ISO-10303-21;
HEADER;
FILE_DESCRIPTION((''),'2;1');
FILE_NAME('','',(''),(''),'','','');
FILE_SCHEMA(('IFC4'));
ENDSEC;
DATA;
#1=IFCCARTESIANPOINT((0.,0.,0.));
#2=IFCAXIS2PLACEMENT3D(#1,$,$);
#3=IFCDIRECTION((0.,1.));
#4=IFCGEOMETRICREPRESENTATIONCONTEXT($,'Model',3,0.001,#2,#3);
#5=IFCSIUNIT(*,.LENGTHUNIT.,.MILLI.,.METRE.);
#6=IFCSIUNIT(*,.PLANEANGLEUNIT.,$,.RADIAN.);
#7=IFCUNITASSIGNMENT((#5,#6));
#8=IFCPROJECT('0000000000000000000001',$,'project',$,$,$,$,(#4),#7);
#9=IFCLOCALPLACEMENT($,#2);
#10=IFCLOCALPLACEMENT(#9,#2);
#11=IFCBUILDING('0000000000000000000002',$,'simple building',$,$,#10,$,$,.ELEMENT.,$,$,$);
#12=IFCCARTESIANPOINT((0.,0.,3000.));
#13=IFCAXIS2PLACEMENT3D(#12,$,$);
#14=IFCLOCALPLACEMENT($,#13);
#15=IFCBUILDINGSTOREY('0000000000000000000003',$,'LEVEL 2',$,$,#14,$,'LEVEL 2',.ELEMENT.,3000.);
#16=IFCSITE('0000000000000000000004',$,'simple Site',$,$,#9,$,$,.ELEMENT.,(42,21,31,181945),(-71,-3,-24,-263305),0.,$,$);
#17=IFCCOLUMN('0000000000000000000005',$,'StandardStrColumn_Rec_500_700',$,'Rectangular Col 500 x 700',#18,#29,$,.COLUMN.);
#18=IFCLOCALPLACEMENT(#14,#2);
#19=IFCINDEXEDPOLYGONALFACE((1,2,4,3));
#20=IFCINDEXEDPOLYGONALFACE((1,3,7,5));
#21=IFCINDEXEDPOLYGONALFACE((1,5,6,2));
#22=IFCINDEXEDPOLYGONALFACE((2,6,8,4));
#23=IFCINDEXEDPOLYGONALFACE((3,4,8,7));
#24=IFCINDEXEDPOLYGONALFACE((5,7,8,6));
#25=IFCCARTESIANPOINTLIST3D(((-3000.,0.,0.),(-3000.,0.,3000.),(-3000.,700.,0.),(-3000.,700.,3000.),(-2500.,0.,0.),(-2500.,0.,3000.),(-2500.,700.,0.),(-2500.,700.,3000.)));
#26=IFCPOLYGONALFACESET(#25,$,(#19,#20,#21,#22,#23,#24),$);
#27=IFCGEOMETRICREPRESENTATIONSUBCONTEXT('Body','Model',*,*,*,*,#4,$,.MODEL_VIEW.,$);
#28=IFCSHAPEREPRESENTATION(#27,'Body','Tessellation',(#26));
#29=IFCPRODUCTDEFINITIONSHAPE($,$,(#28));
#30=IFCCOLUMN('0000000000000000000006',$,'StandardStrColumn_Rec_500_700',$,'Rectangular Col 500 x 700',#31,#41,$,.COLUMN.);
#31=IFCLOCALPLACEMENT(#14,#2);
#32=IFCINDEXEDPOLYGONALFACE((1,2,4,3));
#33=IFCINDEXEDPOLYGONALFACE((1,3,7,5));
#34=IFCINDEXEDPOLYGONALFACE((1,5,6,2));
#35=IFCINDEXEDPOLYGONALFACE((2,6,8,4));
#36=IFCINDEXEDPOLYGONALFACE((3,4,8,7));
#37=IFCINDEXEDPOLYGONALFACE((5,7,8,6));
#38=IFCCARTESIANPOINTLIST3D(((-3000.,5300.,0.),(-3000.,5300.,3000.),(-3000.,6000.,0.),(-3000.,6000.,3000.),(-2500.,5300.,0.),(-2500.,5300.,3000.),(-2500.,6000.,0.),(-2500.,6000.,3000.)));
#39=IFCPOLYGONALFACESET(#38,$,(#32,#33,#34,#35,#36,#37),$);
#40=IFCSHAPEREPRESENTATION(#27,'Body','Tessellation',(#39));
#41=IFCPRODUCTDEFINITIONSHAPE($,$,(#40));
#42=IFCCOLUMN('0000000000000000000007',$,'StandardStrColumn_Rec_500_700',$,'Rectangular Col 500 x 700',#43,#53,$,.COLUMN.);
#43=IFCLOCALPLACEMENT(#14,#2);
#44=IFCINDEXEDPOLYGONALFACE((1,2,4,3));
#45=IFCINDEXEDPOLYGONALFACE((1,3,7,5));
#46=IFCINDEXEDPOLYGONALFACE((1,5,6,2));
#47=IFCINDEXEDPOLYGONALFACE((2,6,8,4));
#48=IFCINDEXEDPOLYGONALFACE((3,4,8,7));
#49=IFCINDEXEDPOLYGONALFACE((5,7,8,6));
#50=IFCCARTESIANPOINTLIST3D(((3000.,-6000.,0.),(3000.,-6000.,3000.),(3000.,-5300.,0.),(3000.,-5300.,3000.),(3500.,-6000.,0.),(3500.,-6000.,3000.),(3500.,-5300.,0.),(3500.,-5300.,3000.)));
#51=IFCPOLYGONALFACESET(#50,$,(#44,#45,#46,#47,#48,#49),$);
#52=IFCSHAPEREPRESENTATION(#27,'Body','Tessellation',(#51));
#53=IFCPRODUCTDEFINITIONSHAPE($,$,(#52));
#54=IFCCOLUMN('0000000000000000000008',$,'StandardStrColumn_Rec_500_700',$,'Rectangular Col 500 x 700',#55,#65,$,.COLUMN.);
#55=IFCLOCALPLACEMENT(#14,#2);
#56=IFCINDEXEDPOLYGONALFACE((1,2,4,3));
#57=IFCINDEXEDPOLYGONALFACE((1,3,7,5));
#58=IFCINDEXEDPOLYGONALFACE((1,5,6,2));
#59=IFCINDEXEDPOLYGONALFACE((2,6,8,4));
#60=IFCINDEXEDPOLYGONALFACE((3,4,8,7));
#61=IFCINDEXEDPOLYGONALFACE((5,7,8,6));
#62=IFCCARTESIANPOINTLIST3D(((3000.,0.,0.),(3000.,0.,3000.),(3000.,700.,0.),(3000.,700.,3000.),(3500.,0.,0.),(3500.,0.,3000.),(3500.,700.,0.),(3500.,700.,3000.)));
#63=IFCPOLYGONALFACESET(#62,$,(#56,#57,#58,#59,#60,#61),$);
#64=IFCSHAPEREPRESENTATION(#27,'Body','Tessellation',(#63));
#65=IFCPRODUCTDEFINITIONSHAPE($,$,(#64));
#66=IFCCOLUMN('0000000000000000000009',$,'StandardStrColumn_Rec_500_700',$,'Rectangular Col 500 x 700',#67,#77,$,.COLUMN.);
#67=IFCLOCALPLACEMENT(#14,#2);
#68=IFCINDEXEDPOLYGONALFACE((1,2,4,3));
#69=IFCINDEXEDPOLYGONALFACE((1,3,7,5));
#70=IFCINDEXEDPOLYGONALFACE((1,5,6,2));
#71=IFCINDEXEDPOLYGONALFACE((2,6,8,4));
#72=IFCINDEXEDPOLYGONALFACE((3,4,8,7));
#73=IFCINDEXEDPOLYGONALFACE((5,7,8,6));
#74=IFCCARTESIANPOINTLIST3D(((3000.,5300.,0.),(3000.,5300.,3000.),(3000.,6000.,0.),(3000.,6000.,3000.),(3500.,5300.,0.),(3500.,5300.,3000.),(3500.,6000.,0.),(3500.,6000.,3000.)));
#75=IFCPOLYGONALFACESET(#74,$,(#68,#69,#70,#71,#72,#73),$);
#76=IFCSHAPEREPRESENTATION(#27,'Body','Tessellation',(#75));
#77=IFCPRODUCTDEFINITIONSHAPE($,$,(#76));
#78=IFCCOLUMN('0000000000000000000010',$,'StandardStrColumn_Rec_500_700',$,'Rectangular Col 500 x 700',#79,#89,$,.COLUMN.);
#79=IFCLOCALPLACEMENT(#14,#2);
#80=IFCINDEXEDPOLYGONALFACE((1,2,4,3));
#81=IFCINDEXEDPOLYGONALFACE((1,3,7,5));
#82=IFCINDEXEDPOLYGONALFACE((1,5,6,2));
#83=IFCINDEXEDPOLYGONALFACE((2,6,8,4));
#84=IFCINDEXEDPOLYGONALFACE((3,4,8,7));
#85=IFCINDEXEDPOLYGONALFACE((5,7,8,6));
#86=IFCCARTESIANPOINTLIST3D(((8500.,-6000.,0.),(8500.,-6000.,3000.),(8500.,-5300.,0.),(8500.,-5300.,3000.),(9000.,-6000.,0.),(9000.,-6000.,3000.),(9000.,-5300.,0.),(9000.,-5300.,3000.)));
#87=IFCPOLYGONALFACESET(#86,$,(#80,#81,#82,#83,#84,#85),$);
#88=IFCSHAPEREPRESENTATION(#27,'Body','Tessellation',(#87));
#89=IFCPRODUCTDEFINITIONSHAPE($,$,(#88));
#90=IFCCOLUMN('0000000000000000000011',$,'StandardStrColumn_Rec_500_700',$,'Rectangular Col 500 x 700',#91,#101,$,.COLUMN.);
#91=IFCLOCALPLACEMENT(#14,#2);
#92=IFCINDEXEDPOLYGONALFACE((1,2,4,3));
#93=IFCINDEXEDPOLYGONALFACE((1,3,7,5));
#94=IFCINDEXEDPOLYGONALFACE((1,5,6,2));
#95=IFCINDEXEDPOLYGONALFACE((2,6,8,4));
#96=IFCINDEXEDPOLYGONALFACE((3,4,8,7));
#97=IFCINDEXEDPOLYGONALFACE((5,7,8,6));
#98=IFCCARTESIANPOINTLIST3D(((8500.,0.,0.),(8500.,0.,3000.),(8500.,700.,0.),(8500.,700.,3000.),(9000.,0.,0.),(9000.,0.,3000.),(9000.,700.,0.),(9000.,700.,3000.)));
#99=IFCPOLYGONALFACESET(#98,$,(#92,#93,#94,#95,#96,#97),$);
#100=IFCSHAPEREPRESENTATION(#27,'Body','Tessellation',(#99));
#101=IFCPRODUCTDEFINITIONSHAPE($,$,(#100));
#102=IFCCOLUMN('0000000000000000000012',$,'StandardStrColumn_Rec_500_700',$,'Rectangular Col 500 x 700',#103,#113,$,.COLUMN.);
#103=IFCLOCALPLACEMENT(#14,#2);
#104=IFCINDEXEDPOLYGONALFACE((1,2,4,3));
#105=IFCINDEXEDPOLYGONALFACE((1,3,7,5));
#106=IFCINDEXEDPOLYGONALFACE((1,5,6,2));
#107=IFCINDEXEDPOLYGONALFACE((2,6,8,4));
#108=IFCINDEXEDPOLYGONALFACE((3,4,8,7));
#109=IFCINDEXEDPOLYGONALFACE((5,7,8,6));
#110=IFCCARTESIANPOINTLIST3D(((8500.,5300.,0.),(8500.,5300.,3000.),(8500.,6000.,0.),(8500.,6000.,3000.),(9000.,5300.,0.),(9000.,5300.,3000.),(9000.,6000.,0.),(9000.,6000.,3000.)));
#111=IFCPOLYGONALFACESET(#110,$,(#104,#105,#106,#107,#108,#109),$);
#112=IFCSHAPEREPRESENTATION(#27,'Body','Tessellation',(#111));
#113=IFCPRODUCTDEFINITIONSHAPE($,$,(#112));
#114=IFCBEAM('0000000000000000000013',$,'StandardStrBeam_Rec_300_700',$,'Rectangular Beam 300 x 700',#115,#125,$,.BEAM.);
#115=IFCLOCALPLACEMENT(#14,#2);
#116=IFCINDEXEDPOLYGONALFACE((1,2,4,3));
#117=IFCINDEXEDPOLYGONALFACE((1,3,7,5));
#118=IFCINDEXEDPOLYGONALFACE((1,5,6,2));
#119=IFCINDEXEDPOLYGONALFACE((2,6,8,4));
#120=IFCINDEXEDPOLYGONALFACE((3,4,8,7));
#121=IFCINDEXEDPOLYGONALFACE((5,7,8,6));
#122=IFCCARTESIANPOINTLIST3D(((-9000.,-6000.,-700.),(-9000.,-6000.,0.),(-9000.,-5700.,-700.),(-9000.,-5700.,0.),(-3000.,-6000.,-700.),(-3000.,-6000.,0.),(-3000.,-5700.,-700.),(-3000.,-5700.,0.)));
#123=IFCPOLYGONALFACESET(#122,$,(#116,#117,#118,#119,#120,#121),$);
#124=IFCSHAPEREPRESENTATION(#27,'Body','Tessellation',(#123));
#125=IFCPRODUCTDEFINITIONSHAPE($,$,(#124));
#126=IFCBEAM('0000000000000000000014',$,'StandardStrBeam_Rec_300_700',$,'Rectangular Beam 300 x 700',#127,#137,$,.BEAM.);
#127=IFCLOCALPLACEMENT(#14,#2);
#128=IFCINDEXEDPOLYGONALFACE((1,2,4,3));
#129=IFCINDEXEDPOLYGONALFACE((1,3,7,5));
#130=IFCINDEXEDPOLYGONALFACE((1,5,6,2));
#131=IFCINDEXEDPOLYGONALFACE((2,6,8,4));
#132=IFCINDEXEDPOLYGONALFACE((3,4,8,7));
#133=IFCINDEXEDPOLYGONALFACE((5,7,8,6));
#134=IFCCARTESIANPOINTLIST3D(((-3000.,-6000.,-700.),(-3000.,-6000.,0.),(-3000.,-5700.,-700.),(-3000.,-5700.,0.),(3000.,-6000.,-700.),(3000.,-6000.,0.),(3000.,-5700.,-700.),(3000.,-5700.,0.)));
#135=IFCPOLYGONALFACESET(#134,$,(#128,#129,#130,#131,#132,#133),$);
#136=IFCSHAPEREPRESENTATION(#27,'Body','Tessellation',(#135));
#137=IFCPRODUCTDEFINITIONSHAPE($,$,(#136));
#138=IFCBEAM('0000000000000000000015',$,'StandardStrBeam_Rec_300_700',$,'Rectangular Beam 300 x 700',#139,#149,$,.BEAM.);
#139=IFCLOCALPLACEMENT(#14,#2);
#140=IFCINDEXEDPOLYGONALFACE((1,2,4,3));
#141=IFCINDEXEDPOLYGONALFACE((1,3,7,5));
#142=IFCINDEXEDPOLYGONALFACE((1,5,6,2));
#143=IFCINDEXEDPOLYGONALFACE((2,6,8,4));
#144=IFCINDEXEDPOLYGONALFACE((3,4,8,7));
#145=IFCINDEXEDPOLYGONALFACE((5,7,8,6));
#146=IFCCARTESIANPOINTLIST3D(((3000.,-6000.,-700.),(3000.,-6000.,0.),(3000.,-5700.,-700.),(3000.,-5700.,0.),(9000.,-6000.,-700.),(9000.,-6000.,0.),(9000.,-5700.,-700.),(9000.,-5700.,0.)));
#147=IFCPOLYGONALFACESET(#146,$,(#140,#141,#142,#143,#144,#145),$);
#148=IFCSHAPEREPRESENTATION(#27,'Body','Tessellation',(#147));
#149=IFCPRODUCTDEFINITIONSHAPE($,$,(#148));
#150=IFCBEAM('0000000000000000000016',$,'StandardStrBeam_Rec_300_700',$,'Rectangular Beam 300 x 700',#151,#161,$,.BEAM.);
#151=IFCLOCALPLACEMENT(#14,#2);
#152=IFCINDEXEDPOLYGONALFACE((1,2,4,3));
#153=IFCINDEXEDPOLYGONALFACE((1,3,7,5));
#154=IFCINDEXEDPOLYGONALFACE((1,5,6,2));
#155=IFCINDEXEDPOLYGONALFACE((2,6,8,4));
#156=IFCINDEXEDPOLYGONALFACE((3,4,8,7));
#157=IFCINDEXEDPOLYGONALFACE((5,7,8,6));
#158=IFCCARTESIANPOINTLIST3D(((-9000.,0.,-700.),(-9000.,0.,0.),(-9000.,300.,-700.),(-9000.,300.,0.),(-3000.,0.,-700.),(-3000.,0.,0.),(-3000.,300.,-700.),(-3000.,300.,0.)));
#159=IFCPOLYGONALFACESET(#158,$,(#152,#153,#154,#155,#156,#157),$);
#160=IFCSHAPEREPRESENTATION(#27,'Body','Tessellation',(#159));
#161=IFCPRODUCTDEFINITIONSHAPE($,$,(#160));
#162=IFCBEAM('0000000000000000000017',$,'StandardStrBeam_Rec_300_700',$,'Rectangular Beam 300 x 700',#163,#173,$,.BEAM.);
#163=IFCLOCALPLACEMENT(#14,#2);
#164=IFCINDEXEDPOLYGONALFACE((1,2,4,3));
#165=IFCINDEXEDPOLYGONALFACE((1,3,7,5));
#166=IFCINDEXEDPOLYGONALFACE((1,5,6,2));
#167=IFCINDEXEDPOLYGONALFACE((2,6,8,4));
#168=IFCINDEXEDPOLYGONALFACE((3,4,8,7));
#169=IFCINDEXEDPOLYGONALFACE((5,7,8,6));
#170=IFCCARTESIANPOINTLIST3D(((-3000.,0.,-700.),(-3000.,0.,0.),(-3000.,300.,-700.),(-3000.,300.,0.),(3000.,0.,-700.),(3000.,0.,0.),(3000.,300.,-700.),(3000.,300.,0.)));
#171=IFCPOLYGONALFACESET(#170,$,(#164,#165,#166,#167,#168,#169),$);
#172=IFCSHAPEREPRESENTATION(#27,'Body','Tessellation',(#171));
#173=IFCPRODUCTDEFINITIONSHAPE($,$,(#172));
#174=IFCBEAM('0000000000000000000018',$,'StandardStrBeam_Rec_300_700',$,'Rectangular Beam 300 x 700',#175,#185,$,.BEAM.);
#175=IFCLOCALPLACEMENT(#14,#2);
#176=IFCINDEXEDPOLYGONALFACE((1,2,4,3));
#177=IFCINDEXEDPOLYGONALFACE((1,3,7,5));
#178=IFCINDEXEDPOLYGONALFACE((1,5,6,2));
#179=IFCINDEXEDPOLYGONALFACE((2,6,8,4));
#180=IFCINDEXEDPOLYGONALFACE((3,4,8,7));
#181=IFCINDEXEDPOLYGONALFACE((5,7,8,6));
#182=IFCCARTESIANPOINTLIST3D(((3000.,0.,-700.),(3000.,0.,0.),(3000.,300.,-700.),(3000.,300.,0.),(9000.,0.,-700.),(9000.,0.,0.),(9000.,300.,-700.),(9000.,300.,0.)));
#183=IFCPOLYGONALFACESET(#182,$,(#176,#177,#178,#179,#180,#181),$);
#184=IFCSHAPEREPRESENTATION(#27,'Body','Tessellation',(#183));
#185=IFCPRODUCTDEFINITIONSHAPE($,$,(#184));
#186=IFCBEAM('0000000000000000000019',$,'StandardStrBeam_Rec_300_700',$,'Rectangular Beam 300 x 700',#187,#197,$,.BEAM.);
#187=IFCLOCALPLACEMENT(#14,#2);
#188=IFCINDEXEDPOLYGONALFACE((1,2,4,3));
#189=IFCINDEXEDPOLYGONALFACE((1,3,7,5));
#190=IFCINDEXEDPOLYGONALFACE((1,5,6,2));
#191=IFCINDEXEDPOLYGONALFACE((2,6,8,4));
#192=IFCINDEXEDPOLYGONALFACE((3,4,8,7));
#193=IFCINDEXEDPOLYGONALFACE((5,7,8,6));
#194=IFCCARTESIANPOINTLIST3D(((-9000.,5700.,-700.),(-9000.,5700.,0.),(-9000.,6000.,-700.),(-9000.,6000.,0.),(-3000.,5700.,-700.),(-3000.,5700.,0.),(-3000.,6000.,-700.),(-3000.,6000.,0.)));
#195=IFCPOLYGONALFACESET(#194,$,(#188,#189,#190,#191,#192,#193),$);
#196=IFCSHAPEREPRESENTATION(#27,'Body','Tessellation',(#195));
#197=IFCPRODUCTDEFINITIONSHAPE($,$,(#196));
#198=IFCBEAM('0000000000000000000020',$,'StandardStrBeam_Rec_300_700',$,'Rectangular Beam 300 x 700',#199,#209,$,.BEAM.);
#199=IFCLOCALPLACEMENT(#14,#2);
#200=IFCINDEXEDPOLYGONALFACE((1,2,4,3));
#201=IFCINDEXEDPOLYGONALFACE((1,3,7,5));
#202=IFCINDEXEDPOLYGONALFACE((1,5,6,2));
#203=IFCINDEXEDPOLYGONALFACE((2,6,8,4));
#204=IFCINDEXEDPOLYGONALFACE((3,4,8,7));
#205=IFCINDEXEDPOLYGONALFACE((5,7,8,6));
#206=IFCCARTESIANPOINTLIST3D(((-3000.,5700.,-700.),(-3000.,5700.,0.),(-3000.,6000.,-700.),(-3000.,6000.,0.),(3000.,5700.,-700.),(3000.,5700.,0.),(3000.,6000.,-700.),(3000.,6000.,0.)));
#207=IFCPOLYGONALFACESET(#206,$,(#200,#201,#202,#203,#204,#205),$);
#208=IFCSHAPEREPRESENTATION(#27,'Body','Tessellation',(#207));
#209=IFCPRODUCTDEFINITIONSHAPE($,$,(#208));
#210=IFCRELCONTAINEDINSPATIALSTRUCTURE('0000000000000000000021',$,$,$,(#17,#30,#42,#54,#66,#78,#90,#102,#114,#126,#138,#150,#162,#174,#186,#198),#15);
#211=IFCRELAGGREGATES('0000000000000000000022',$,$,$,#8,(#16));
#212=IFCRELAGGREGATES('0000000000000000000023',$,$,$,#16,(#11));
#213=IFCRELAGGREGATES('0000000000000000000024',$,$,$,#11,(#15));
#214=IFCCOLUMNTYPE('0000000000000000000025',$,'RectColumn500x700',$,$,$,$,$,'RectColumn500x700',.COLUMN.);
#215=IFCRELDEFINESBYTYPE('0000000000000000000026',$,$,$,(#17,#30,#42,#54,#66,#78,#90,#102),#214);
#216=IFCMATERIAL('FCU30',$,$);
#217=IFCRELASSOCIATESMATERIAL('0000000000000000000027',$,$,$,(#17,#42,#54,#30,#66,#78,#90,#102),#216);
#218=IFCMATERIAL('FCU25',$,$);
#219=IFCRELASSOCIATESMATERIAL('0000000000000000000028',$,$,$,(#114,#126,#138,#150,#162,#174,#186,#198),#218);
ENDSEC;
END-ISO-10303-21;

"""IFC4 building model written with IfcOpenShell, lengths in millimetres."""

from ifc_helpers import new_model, si_unit, direction, frame, origin, origin_with_axes, origin_2d_with_axis, place, context, subcontext, project, spatial, rectangle, extrude, material, material_profile, profile_set, profile_usage, type_object, element, save


model = new_model("IFC4")

# Units and contexts
model_context = context("Model", 3, precision=0.001, world=origin(), true_north=direction((0.0, 1.0)))
body_context = subcontext(model_context, "Body", "Model", "MODEL_VIEW")
ifc_project = project(units=[si_unit("LENGTHUNIT", "METRE", prefix="MILLI"), si_unit("PLANEANGLEUNIT", "RADIAN")], contexts=[model_context])

# Site, building, storey
site_placement = place(None, origin())
site = spatial("IfcSite", under=ifc_project, at=site_placement, Name="simple Site", CompositionType="ELEMENT", RefLatitude=(42, 21, 31, 181945), RefLongitude=(-71, -3, -24, -263305), RefElevation=0.0)
building_placement = place(site_placement, origin())
building = spatial("IfcBuilding", under=site, at=building_placement, Name="simple building", CompositionType="ELEMENT")
storey_placement = place(None, frame((0.0, 0.0, 3000.0)))
storey = spatial("IfcBuildingStorey", under=building, at=storey_placement, Name="LEVEL 2", LongName="LEVEL 2", CompositionType="ELEMENT", Elevation=3000.0)

# Columns
ifc_material_1 = material(Name="FCU30")
ifc_material_profile_1 = material_profile(ifc_material_1, rectangle(XDim=500.0, YDim=700.0, at=origin_2d_with_axis()))
ifc_profile_set_1 = profile_set([ifc_material_profile_1])
ifc_profile_usage_1 = profile_usage(ifc_profile_set_1, cardinal=7)
column_type = type_object("IfcColumnType", Name="RectColumn500x700", ElementType="RectColumn500x700", PredefinedType="COLUMN")
column_1_placement = place(None, frame((-2750.0, 350.0, 3000.0), z_axis=(0.0, 0.0, 1.0), x_axis=(1.0, 0.0, 0.0)))
element("IfcColumn", 1, at=column_1_placement, inside=storey, type_object=column_type, material=ifc_profile_usage_1, Name="StandardStrColumn_Rec_500_700", ObjectType="Rectangular Col 500 x 700", PredefinedType="COLUMN", context=body_context, shape_type="SweptSolid", body=[
    extrude(rectangle(XDim=500.0, YDim=700.0, at=origin_2d_with_axis()), origin_with_axes(), (0.0, 0.0, 1.0), 3000.0),
])
ifc_profile_usage_2 = profile_usage(ifc_profile_set_1, cardinal=1)
column_2_placement = place(None, frame((-2750.0, 5650.0, 3000.0), z_axis=(0.0, 0.0, 1.0), x_axis=(1.0, 0.0, 0.0)))
element("IfcColumn", 2, at=column_2_placement, inside=storey, type_object=column_type, material=ifc_profile_usage_2, Name="StandardStrColumn_Rec_500_700", ObjectType="Rectangular Col 500 x 700", PredefinedType="COLUMN", context=body_context, shape_type="SweptSolid", body=[
    extrude(rectangle(XDim=500.0, YDim=700.0, at=origin_2d_with_axis()), origin_with_axes(), (0.0, 0.0, 1.0), 3000.0),
])
for number, where, z_axis, x_axis, name in (
    (3, (3250.0, -5650.0, 3000.0), (0.0, 0.0, 1.0), (1.0, 0.0, 0.0), "StandardStrColumn_Rec_500_700"),
    (4, (3250.0, 350.0, 3000.0), (0.0, 0.0, 1.0), (1.0, 0.0, 0.0), "StandardStrColumn_Rec_500_700"),
):
    element("IfcColumn", number, at=place(None, frame(where, z_axis=z_axis, x_axis=x_axis)), inside=storey, type_object=column_type, material=ifc_profile_usage_1, Name=name, ObjectType="Rectangular Col 500 x 700", PredefinedType="COLUMN", context=body_context, shape_type="SweptSolid", body=[
        extrude(rectangle(XDim=500.0, YDim=700.0, at=origin_2d_with_axis()), origin_with_axes(), (0.0, 0.0, 1.0), 3000.0),
    ])
column_3_placement = place(None, frame((3250.0, 5650.0, 3000.0), z_axis=(0.0, 0.0, 1.0), x_axis=(1.0, 0.0, 0.0)))
element("IfcColumn", 5, at=column_3_placement, inside=storey, type_object=column_type, material=ifc_profile_usage_2, Name="StandardStrColumn_Rec_500_700", ObjectType="Rectangular Col 500 x 700", PredefinedType="COLUMN", context=body_context, shape_type="SweptSolid", body=[
    extrude(rectangle(XDim=500.0, YDim=700.0, at=origin_2d_with_axis()), origin_with_axes(), (0.0, 0.0, 1.0), 3000.0),
])
ifc_profile_usage_3 = profile_usage(ifc_profile_set_1, cardinal=9)
for number, where, z_axis, x_axis, name in (
    (6, (8750.0, -5650.0, 3000.0), (0.0, 0.0, 1.0), (1.0, 0.0, 0.0), "StandardStrColumn_Rec_500_700"),
    (7, (8750.0, 350.0, 3000.0), (0.0, 0.0, 1.0), (1.0, 0.0, 0.0), "StandardStrColumn_Rec_500_700"),
):
    element("IfcColumn", number, at=place(None, frame(where, z_axis=z_axis, x_axis=x_axis)), inside=storey, type_object=column_type, material=ifc_profile_usage_3, Name=name, ObjectType="Rectangular Col 500 x 700", PredefinedType="COLUMN", context=body_context, shape_type="SweptSolid", body=[
        extrude(rectangle(XDim=500.0, YDim=700.0, at=origin_2d_with_axis()), origin_with_axes(), (0.0, 0.0, 1.0), 3000.0),
    ])
ifc_profile_usage_4 = profile_usage(ifc_profile_set_1, cardinal=3)
column_4_placement = place(None, frame((8750.0, 5650.0, 3000.0), z_axis=(0.0, 0.0, 1.0), x_axis=(1.0, 0.0, 0.0)))
element("IfcColumn", 8, at=column_4_placement, inside=storey, type_object=column_type, material=ifc_profile_usage_4, Name="StandardStrColumn_Rec_500_700", ObjectType="Rectangular Col 500 x 700", PredefinedType="COLUMN", context=body_context, shape_type="SweptSolid", body=[
    extrude(rectangle(XDim=500.0, YDim=700.0, at=origin_2d_with_axis()), origin_with_axes(), (0.0, 0.0, 1.0), 3000.0),
])

# Beams
ifc_material_2 = material(Name="FCU25")
ifc_material_profile_2 = material_profile(ifc_material_2, rectangle(XDim=300.0, YDim=700.0, at=origin_2d_with_axis()))
ifc_profile_set_2 = profile_set([ifc_material_profile_2])
ifc_profile_usage_5 = profile_usage(ifc_profile_set_2, cardinal=9)
for number, where, z_axis, x_axis, name in (
    (9, (-9000.0, -5850.0, 2650.0), (1.0, 0.0, 0.0), (0.0, -1.0, 0.0), "StandardStrBeam_Rec_300_700"),
    (10, (-3000.0, -5850.0, 2650.0), (1.0, 0.0, 0.0), (0.0, -1.0, 0.0), "StandardStrBeam_Rec_300_700"),
    (11, (3000.0, -5850.0, 2650.0), (1.0, 0.0, 0.0), (0.0, -1.0, 0.0), "StandardStrBeam_Rec_300_700"),
    (12, (-9000.0, 150.0, 2650.0), (1.0, 0.0, 0.0), (0.0, -1.0, 0.0), "StandardStrBeam_Rec_300_700"),
    (13, (-3000.0, 150.0, 2650.0), (1.0, 0.0, 0.0), (0.0, -1.0, 0.0), "StandardStrBeam_Rec_300_700"),
    (14, (3000.0, 150.0, 2650.0), (1.0, 0.0, 0.0), (0.0, -1.0, 0.0), "StandardStrBeam_Rec_300_700"),
):
    element("IfcBeam", number, at=place(None, frame(where, z_axis=z_axis, x_axis=x_axis)), inside=storey, material=ifc_profile_usage_5, Name=name, ObjectType="Rectangular Beam 300 x 700", PredefinedType="BEAM", context=body_context, shape_type="SweptSolid", body=[
        extrude(rectangle(XDim=300.0, YDim=700.0, at=origin_2d_with_axis()), origin_with_axes(), (0.0, 0.0, 1.0), 6000.0),
    ])
ifc_profile_usage_6 = profile_usage(ifc_profile_set_2, cardinal=7)
for number, where, z_axis, x_axis, name in (
    (15, (-9000.0, 5850.0, 2650.0), (1.0, 0.0, 0.0), (0.0, -1.0, 0.0), "StandardStrBeam_Rec_300_700"),
    (16, (-3000.0, 5850.0, 2650.0), (1.0, 0.0, 0.0), (0.0, -1.0, 0.0), "StandardStrBeam_Rec_300_700"),
):
    element("IfcBeam", number, at=place(None, frame(where, z_axis=z_axis, x_axis=x_axis)), inside=storey, material=ifc_profile_usage_6, Name=name, ObjectType="Rectangular Beam 300 x 700", PredefinedType="BEAM", context=body_context, shape_type="SweptSolid", body=[
        extrude(rectangle(XDim=300.0, YDim=700.0, at=origin_2d_with_axis()), origin_with_axes(), (0.0, 0.0, 1.0), 6000.0),
    ])

save(model, "model.ifc")
